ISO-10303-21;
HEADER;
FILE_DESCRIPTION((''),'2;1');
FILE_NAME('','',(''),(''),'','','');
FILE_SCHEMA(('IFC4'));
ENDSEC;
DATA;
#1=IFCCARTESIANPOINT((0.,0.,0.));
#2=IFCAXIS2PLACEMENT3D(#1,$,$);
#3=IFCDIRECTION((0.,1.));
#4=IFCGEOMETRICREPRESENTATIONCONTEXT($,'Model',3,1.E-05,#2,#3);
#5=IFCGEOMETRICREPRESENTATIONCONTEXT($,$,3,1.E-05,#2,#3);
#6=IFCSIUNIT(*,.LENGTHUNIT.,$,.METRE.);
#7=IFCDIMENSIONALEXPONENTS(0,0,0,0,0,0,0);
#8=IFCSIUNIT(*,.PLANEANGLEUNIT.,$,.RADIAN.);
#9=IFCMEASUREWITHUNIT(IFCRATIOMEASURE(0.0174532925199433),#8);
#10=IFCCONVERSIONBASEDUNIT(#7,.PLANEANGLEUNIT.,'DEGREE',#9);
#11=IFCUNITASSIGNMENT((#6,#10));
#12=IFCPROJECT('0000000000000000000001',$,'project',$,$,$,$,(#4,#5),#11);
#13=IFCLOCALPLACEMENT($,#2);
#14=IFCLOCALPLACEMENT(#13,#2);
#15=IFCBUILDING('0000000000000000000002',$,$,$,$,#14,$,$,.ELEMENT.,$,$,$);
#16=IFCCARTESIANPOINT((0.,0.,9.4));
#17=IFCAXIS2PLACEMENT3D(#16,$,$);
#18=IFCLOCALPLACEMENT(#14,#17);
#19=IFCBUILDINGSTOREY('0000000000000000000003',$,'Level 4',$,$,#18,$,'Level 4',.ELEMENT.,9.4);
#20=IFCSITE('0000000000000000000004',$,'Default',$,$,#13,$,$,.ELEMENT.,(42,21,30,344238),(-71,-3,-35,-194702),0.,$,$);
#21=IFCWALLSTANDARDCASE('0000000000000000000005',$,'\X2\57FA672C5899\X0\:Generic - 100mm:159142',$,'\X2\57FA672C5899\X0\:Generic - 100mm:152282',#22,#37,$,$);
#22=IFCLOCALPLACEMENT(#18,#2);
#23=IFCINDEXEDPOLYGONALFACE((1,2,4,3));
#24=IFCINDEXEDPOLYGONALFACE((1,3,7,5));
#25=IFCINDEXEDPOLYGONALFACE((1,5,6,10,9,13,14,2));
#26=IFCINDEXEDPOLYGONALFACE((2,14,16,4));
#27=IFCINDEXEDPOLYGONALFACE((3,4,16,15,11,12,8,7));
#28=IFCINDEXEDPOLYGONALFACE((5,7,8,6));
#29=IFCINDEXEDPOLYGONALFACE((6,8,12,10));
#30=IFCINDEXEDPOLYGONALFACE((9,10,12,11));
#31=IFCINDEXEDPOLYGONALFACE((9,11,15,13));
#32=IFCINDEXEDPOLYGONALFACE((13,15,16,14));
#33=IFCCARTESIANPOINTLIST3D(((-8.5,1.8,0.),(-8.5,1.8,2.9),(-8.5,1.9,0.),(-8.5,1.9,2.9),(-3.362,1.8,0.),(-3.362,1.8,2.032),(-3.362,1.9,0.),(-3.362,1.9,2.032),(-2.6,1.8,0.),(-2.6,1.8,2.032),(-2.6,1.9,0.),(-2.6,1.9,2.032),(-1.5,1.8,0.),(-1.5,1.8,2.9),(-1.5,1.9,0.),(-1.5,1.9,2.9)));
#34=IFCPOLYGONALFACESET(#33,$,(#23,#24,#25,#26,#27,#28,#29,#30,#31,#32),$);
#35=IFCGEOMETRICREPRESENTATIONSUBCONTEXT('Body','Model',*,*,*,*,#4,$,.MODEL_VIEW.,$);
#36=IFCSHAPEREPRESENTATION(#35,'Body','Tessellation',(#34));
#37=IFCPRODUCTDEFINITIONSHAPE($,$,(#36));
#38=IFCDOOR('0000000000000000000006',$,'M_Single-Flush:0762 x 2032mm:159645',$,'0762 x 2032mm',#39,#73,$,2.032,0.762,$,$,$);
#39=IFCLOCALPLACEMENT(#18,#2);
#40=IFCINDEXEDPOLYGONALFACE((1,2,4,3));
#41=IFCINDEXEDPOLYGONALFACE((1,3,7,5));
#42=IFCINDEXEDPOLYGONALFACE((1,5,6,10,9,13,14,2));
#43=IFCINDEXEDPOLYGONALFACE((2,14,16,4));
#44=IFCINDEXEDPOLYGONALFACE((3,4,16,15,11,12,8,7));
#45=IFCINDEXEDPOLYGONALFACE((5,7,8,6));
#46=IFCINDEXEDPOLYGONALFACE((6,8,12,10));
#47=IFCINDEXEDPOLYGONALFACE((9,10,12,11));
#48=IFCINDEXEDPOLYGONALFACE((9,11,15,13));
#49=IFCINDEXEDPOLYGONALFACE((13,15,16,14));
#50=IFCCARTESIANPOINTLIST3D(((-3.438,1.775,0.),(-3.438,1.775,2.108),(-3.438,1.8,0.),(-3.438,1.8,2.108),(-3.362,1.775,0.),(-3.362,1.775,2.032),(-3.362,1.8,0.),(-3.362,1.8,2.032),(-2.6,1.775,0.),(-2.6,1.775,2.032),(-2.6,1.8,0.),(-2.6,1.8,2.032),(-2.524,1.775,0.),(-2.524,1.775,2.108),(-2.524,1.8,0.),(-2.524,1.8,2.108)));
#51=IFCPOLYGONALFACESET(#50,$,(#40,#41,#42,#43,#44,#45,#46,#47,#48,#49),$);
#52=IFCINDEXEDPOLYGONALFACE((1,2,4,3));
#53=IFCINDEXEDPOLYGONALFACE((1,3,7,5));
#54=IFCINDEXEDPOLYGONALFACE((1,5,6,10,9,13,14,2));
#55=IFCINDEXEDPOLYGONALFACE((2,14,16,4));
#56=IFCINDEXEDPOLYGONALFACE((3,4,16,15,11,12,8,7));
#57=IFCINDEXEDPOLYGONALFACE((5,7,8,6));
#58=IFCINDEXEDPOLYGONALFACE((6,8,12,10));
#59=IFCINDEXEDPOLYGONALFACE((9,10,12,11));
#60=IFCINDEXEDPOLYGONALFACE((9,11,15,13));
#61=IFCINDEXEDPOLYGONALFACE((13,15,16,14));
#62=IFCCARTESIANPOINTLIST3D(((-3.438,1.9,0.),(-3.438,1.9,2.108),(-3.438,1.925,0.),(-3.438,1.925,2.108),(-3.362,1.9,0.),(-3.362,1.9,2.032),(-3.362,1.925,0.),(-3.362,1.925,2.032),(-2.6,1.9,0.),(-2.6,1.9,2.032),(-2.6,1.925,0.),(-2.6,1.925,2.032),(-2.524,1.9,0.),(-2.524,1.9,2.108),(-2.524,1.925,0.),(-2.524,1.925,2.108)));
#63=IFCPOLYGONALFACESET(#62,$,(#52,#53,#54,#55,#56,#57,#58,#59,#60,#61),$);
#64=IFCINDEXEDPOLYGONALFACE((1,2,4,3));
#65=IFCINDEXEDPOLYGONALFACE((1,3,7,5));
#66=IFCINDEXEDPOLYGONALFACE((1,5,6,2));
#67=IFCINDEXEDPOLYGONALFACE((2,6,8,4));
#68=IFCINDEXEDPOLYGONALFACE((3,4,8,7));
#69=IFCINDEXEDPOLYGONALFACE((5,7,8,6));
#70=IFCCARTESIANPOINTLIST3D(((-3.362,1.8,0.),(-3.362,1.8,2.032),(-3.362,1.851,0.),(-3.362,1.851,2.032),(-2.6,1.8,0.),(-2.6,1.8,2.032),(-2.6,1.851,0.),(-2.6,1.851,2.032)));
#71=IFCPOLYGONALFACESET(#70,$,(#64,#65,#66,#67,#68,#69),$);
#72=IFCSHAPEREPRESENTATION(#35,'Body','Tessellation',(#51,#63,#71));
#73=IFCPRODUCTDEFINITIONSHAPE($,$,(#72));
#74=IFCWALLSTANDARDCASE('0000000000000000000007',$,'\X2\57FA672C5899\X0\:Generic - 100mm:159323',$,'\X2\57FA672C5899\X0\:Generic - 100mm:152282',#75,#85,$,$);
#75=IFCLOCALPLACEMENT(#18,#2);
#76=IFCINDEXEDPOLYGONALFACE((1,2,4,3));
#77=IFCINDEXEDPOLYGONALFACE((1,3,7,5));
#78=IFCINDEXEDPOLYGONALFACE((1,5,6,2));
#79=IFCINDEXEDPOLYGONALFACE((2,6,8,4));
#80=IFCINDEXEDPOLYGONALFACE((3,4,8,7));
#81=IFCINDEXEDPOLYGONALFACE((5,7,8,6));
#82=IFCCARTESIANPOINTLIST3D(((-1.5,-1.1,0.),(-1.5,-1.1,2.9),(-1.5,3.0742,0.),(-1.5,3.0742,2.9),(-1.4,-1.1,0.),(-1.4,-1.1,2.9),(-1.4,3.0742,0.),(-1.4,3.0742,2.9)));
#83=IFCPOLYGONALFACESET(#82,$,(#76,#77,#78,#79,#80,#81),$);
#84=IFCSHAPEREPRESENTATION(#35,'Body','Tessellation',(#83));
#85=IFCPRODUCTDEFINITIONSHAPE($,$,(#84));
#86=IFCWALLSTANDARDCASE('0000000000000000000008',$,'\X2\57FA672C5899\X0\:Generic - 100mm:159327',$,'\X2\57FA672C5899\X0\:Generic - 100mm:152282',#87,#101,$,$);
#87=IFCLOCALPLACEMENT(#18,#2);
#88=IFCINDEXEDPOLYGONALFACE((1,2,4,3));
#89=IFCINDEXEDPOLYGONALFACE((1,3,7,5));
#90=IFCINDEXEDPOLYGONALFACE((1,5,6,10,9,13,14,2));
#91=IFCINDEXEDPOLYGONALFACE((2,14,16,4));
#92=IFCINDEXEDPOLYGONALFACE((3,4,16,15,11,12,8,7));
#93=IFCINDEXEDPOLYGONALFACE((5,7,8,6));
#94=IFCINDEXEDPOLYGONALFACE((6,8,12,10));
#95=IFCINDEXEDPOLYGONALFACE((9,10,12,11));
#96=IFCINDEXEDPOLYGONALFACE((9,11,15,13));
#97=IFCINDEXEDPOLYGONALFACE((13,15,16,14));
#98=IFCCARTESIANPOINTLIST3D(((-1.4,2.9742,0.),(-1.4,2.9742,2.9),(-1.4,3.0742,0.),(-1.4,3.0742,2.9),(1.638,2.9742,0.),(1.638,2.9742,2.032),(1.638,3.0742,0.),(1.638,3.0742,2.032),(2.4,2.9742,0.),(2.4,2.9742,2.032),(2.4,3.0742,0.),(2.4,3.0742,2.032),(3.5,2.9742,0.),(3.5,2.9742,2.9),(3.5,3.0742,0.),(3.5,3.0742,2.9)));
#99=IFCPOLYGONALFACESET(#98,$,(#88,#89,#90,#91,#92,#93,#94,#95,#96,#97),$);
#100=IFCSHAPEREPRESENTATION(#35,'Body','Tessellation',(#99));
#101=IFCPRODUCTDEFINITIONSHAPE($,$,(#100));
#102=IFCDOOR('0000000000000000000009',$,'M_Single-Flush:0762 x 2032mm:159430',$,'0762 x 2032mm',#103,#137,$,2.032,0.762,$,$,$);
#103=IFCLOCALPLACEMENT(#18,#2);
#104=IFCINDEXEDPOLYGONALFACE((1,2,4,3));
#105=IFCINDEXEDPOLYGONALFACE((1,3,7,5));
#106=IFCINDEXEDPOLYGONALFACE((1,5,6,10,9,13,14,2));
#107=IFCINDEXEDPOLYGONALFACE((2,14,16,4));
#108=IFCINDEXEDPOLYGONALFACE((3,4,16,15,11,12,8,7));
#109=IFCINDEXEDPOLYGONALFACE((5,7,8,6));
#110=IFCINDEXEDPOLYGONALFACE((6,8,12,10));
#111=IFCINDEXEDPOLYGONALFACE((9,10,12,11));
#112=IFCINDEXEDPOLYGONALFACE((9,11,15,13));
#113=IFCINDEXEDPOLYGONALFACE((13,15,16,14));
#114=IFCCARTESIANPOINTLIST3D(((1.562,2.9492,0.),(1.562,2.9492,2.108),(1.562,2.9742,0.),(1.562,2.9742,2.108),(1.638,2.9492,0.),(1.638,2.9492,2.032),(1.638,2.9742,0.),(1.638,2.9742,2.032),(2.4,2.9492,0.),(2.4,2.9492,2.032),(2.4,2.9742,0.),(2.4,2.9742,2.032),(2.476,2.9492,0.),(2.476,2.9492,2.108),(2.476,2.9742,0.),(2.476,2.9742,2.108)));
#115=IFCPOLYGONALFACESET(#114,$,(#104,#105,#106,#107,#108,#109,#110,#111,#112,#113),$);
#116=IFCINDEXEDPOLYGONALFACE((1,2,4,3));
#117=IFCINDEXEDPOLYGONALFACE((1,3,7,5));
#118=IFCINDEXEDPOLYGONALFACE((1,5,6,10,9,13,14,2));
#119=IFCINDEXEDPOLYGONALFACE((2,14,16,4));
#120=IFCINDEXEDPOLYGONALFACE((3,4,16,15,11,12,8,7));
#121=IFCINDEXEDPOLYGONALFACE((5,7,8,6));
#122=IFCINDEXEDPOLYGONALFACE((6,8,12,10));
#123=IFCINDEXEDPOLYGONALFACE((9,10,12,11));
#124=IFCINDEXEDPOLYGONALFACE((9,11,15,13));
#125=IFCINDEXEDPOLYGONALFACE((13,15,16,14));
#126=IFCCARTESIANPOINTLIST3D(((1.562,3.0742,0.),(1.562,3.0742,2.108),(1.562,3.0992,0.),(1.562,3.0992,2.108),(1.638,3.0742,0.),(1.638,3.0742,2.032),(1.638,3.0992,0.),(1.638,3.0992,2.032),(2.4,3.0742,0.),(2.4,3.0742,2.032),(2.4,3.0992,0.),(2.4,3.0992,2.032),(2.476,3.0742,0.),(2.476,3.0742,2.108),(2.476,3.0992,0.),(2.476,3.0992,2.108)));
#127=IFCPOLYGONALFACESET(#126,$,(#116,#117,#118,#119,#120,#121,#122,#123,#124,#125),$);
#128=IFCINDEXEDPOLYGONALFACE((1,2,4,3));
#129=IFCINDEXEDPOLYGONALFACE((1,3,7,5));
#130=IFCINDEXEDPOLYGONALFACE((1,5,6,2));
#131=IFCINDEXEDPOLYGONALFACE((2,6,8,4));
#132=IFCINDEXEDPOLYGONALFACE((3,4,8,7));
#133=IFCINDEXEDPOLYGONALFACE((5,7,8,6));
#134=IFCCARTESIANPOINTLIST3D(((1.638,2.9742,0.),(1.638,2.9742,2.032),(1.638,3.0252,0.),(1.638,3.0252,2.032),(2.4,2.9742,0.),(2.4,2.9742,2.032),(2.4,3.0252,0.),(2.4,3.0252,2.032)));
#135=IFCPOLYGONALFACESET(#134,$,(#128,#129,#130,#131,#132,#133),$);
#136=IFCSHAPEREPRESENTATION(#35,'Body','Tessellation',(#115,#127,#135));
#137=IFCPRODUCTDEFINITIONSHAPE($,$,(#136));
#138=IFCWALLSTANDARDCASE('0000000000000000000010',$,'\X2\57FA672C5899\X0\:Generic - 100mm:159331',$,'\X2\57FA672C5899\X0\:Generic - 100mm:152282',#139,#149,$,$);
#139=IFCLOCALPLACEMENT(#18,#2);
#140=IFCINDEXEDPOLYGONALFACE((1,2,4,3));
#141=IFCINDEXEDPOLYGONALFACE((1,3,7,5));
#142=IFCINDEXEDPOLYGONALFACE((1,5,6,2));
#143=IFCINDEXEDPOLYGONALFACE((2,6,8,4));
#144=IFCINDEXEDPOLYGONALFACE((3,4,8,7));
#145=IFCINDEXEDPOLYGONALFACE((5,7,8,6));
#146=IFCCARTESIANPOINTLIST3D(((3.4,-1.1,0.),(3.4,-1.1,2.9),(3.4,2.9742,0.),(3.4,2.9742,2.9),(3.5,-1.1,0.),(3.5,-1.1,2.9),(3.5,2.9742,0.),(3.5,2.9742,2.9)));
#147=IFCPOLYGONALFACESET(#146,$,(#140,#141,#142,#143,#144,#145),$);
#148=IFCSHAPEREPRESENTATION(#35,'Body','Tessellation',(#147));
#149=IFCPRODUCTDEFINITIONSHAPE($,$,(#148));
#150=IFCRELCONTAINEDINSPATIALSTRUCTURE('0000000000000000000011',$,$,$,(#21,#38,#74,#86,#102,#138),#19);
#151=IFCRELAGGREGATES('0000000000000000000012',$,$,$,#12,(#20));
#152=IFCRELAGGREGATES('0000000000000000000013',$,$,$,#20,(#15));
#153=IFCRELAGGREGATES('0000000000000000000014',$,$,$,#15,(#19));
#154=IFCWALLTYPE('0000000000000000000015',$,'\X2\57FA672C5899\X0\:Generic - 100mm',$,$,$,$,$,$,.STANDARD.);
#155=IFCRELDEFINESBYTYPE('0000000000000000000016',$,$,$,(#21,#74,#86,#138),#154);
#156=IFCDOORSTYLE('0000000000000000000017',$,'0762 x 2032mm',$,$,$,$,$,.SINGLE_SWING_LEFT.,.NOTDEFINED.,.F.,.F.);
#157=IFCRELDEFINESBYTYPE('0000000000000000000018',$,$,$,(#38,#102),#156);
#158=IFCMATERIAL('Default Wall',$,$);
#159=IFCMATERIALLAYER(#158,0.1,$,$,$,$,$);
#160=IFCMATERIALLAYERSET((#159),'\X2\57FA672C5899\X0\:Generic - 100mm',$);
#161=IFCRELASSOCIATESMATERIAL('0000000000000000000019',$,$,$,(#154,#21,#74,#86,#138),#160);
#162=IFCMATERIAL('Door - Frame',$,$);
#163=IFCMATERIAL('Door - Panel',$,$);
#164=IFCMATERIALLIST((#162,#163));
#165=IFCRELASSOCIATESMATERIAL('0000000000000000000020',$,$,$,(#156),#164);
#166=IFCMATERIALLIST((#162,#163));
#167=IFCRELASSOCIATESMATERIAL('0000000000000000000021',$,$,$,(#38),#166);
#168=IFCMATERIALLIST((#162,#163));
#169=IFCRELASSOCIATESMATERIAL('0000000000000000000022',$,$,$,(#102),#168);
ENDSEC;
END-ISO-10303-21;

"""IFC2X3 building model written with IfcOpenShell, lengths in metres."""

from ifc_helpers import new_model, entity, si_unit, converted_unit, direction, frame, frame_2d, origin, origin_2d_with_axis, place, context, subcontext, project, spatial, polyline, rectangle, outline, extrude, clip, bounded_halfspace, source, transform, mapped, material, material_list, layer, layer_set, layer_usage, type_object, type_shapes, element, fill, save


model = new_model("IFC2X3")

# Units and contexts
model_context = context("Model", 3, precision=1e-05, world=origin(), true_north=direction((0.0, 1.0)))
context_of_model = context(None, 3, precision=1e-05, world=origin(), true_north=direction((0.0, 1.0)))
body_context = subcontext(model_context, "Body", "Model", "MODEL_VIEW")
ifc_project = project(units=[si_unit("LENGTHUNIT", "METRE"), converted_unit("PLANEANGLEUNIT", "DEGREE", entity("IfcRatioMeasure", 0.0174532925199433), si_unit("PLANEANGLEUNIT", "RADIAN"), dimensions=[0, 0, 0, 0, 0, 0, 0])], contexts=[model_context, context_of_model])

# Site, building, storey
site_placement = place(None, origin())
site = spatial("IfcSite", under=ifc_project, at=site_placement, Name="Default", CompositionType="ELEMENT", RefLatitude=(42, 21, 30, 344238), RefLongitude=(-71, -3, -35, -194702), RefElevation=0.0)
building_placement = place(site_placement, origin())
building = spatial("IfcBuilding", under=site, at=building_placement, CompositionType="ELEMENT")
storey_placement = place(building_placement, frame((0.0, 0.0, 9.4)))
storey = spatial("IfcBuildingStorey", under=building, at=storey_placement, Name="Level 4", LongName="Level 4", CompositionType="ELEMENT", Elevation=9.4)

# Shared definitions
ifc_material_1 = material(Name="Default Wall")

# Wall, opening, door
ifc_layer_1 = layer(ifc_material_1, 0.1)
ifc_layer_set_1 = layer_set([ifc_layer_1], Name="基本墙:Generic - 100mm")
ifc_layer_usage_1 = layer_usage(ifc_layer_set_1, "AXIS2", "NEGATIVE", 0.05)
wall_type_1 = type_object("IfcWallType", Name="基本墙:Generic - 100mm", PredefinedType="STANDARD", material=ifc_layer_set_1)
wall_1_placement = place(storey_placement, frame((-1.5, 1.85, 0.0), z_axis=(0.0, 0.0, 1.0), x_axis=(-1.0, 0.0, 0.0)))
wall_1 = element("IfcWallStandardCase", 1, at=wall_1_placement, inside=storey, type_object=wall_type_1, material=ifc_layer_usage_1, Name="基本墙:Generic - 100mm:159142", ObjectType="基本墙:Generic - 100mm:152282", context=body_context, shape_type="Clipping", body=[
    clip(extrude(rectangle(XDim=7.0, YDim=0.1, at=frame_2d((3.5, 0.0), x_axis=(-1.0, 0.0))), origin(), (0.0, 0.0, 1.0), 3.2), bounded_halfspace(frame((0.0, -0.05, 2.9), z_axis=(0.0, 0.0, -1.0), x_axis=(0.0, 1.0, 0.0)), True, frame((0.0, -0.05, 2.9), z_axis=(0.0, 0.0, -1.0), x_axis=(0.0, 1.0, 0.0)), polyline([(0.0, 0.0), (0.1, 0.0), (0.1, 7.0), (0.0, 7.0), (0.0, 0.0)]))),
])
opening_1_placement = place(wall_1_placement, frame((1.1, -0.05, 0.0)))
opening_1 = element("IfcOpeningElement", 2, at=opening_1_placement, cuts=wall_1, ObjectType="Opening", context=body_context, shape_type="SweptSolid", body=[
    extrude(rectangle(XDim=0.762, YDim=2.032, at=frame_2d((1.016, 0.381), x_axis=(0.0, -1.0))), frame((0.0, 0.0, 0.0), z_axis=(0.0, 1.0, 0.0), x_axis=(0.0, 0.0, 1.0)), (0.0, 0.0, 1.0), 0.1),
])
ifc_material_2 = material(Name="Door - Frame")
ifc_material_3 = material(Name="Door - Panel")
ifc_material_list_1 = material_list([ifc_material_2, ifc_material_3])
ifc_material_list_2 = material_list([ifc_material_2, ifc_material_3])
door_style = type_object("IfcDoorStyle", Name="0762 x 2032mm", ConstructionType="NOTDEFINED", OperationType="SINGLE_SWING_LEFT", ParameterTakesPrecedence=False, Sizeable=False, material=ifc_material_list_2)
shared_shape_1 = source(origin(), body_context, "Body", "SweptSolid", [
    extrude(outline(polyline([(-0.457, -1.073), (0.457, -1.073), (0.457, 1.035), (0.381, 1.035), (0.381, -0.997), (-0.381, -0.997), (-0.381, 1.035), (-0.457, 1.035), (-0.457, -1.073)])), frame((0.381, 0.125, 1.035), z_axis=(0.0, -1.0, 0.0), x_axis=(-1.0, 0.0, 0.0)), (0.0, 0.0, 1.0), 0.025),
    extrude(outline(polyline([(-1.073, -0.457), (1.035, -0.457), (1.035, -0.381), (-0.997, -0.381), (-0.997, 0.381), (1.035, 0.381), (1.035, 0.457), (-1.073, 0.457), (-1.073, -0.457)])), frame((0.381, 0.0, 1.035), z_axis=(0.0, -1.0, 0.0), x_axis=(0.0, 0.0, -1.0)), (0.0, 0.0, 1.0), 0.025),
    extrude(rectangle(XDim=0.762, YDim=0.051, at=origin_2d_with_axis()), frame((0.381, 0.0745, 0.0)), (0.0, 0.0, 1.0), 2.032),
])
type_shapes(door_style, [shared_shape_1])
door_1_placement = place(opening_1_placement, origin())
door_1 = element("IfcDoor", 3, at=door_1_placement, inside=storey, type_object=door_style, material=ifc_material_list_1, Name="M_Single-Flush:0762 x 2032mm:159645", ObjectType="0762 x 2032mm", OverallHeight=2.032, OverallWidth=0.762, context=body_context, shape_type="MappedRepresentation", body=[
    mapped(shared_shape_1, transform((0.0, 0.0, 0.0), scale=1.0)),
])
fill(opening_1, door_1)

# Wall
ifc_layer_usage_2 = layer_usage(ifc_layer_set_1, "AXIS2", "NEGATIVE", 0.05)
wall_2_placement = place(storey_placement, frame((-1.45, 3.0742, 0.0), z_axis=(0.0, 0.0, 1.0), x_axis=(0.0, -1.0, 0.0)))
element("IfcWallStandardCase", 4, at=wall_2_placement, inside=storey, type_object=wall_type_1, material=ifc_layer_usage_2, Name="基本墙:Generic - 100mm:159323", ObjectType="基本墙:Generic - 100mm:152282", context=body_context, shape_type="Clipping", body=[
    clip(extrude(rectangle(XDim=4.1742, YDim=0.1, at=frame_2d((2.0871, 0.0), x_axis=(-1.0, 0.0))), origin(), (0.0, 0.0, 1.0), 3.2), bounded_halfspace(frame((0.0, -0.05, 2.9), z_axis=(0.0, 0.0, -1.0), x_axis=(1.0, 0.0, 0.0)), True, frame((0.0, -0.05, 2.9), z_axis=(0.0, 0.0, -1.0), x_axis=(1.0, 0.0, 0.0)), polyline([(0.0, 0.0), (0.0, -0.1), (0.1, -0.1), (4.1742, -0.1), (4.1742, 0.0), (1.2742, 0.0), (1.1742, 0.0), (0.0, 0.0)]))),
])

# Wall, opening, door
ifc_layer_usage_3 = layer_usage(ifc_layer_set_1, "AXIS2", "NEGATIVE", 0.05)
wall_3_placement = place(storey_placement, frame((-1.4, 3.0242, 0.0)))
wall_3 = element("IfcWallStandardCase", 5, at=wall_3_placement, inside=storey, type_object=wall_type_1, material=ifc_layer_usage_3, Name="基本墙:Generic - 100mm:159327", ObjectType="基本墙:Generic - 100mm:152282", context=body_context, shape_type="Clipping", body=[
    clip(extrude(rectangle(XDim=4.9, YDim=0.1, at=frame_2d((2.45, 0.0), x_axis=(-1.0, 0.0))), origin(), (0.0, 0.0, 1.0), 3.2), bounded_halfspace(frame((0.0, -0.05, 2.9), z_axis=(0.0, 0.0, -1.0), x_axis=(0.0, -1.0, 0.0)), True, frame((0.0, -0.05, 2.9), z_axis=(0.0, 0.0, -1.0), x_axis=(0.0, -1.0, 0.0)), polyline([(0.0, 0.0), (-0.1, 0.0), (-0.1, -4.9), (0.0, -4.9), (0.0, 0.0)]))),
])
opening_2_placement = place(wall_3_placement, frame((3.8, 0.05, 0.0)))
opening_2 = element("IfcOpeningElement", 6, at=opening_2_placement, cuts=wall_3, ObjectType="Opening", context=body_context, shape_type="SweptSolid", body=[
    extrude(rectangle(XDim=0.762, YDim=2.032, at=frame_2d((1.016, 0.381), x_axis=(0.0, -1.0))), frame((0.0, 0.0, 0.0), z_axis=(0.0, -1.0, 0.0), x_axis=(0.0, 0.0, 1.0)), (0.0, 0.0, 1.0), 0.1),
])
ifc_material_list_3 = material_list([ifc_material_2, ifc_material_3])
door_2_placement = place(opening_2_placement, frame((0.0, 0.0, 0.0), z_axis=(0.0, 0.0, 1.0), x_axis=(-1.0, 0.0, 0.0)))
door_2 = element("IfcDoor", 7, at=door_2_placement, inside=storey, type_object=door_style, material=ifc_material_list_3, Name="M_Single-Flush:0762 x 2032mm:159430", ObjectType="0762 x 2032mm", OverallHeight=2.032, OverallWidth=0.762, context=body_context, shape_type="MappedRepresentation", body=[
    mapped(shared_shape_1, transform((0.0, 0.0, 0.0), scale=1.0)),
])
fill(opening_2, door_2)

# Wall
ifc_layer_usage_4 = layer_usage(ifc_layer_set_1, "AXIS2", "NEGATIVE", 0.05)
wall_4_placement = place(storey_placement, frame((3.45, 2.9742, 0.0), z_axis=(0.0, 0.0, 1.0), x_axis=(0.0, -1.0, 0.0)))
element("IfcWallStandardCase", 8, at=wall_4_placement, inside=storey, type_object=wall_type_1, material=ifc_layer_usage_4, Name="基本墙:Generic - 100mm:159331", ObjectType="基本墙:Generic - 100mm:152282", context=body_context, shape_type="Clipping", body=[
    clip(extrude(rectangle(XDim=4.0742, YDim=0.1, at=frame_2d((2.0371, 0.0), x_axis=(-1.0, 0.0))), origin(), (0.0, 0.0, 1.0), 3.2), bounded_halfspace(frame((0.0, -0.05, 2.9), z_axis=(0.0, 0.0, -1.0), x_axis=(1.0, 0.0, 0.0)), True, frame((0.0, -0.05, 2.9), z_axis=(0.0, 0.0, -1.0), x_axis=(1.0, 0.0, 0.0)), polyline([(0.0, 0.0), (0.0, -0.1), (4.0742, -0.1), (4.0742, 0.0), (0.0, 0.0)]))),
])

save(model, "model.ifc")
